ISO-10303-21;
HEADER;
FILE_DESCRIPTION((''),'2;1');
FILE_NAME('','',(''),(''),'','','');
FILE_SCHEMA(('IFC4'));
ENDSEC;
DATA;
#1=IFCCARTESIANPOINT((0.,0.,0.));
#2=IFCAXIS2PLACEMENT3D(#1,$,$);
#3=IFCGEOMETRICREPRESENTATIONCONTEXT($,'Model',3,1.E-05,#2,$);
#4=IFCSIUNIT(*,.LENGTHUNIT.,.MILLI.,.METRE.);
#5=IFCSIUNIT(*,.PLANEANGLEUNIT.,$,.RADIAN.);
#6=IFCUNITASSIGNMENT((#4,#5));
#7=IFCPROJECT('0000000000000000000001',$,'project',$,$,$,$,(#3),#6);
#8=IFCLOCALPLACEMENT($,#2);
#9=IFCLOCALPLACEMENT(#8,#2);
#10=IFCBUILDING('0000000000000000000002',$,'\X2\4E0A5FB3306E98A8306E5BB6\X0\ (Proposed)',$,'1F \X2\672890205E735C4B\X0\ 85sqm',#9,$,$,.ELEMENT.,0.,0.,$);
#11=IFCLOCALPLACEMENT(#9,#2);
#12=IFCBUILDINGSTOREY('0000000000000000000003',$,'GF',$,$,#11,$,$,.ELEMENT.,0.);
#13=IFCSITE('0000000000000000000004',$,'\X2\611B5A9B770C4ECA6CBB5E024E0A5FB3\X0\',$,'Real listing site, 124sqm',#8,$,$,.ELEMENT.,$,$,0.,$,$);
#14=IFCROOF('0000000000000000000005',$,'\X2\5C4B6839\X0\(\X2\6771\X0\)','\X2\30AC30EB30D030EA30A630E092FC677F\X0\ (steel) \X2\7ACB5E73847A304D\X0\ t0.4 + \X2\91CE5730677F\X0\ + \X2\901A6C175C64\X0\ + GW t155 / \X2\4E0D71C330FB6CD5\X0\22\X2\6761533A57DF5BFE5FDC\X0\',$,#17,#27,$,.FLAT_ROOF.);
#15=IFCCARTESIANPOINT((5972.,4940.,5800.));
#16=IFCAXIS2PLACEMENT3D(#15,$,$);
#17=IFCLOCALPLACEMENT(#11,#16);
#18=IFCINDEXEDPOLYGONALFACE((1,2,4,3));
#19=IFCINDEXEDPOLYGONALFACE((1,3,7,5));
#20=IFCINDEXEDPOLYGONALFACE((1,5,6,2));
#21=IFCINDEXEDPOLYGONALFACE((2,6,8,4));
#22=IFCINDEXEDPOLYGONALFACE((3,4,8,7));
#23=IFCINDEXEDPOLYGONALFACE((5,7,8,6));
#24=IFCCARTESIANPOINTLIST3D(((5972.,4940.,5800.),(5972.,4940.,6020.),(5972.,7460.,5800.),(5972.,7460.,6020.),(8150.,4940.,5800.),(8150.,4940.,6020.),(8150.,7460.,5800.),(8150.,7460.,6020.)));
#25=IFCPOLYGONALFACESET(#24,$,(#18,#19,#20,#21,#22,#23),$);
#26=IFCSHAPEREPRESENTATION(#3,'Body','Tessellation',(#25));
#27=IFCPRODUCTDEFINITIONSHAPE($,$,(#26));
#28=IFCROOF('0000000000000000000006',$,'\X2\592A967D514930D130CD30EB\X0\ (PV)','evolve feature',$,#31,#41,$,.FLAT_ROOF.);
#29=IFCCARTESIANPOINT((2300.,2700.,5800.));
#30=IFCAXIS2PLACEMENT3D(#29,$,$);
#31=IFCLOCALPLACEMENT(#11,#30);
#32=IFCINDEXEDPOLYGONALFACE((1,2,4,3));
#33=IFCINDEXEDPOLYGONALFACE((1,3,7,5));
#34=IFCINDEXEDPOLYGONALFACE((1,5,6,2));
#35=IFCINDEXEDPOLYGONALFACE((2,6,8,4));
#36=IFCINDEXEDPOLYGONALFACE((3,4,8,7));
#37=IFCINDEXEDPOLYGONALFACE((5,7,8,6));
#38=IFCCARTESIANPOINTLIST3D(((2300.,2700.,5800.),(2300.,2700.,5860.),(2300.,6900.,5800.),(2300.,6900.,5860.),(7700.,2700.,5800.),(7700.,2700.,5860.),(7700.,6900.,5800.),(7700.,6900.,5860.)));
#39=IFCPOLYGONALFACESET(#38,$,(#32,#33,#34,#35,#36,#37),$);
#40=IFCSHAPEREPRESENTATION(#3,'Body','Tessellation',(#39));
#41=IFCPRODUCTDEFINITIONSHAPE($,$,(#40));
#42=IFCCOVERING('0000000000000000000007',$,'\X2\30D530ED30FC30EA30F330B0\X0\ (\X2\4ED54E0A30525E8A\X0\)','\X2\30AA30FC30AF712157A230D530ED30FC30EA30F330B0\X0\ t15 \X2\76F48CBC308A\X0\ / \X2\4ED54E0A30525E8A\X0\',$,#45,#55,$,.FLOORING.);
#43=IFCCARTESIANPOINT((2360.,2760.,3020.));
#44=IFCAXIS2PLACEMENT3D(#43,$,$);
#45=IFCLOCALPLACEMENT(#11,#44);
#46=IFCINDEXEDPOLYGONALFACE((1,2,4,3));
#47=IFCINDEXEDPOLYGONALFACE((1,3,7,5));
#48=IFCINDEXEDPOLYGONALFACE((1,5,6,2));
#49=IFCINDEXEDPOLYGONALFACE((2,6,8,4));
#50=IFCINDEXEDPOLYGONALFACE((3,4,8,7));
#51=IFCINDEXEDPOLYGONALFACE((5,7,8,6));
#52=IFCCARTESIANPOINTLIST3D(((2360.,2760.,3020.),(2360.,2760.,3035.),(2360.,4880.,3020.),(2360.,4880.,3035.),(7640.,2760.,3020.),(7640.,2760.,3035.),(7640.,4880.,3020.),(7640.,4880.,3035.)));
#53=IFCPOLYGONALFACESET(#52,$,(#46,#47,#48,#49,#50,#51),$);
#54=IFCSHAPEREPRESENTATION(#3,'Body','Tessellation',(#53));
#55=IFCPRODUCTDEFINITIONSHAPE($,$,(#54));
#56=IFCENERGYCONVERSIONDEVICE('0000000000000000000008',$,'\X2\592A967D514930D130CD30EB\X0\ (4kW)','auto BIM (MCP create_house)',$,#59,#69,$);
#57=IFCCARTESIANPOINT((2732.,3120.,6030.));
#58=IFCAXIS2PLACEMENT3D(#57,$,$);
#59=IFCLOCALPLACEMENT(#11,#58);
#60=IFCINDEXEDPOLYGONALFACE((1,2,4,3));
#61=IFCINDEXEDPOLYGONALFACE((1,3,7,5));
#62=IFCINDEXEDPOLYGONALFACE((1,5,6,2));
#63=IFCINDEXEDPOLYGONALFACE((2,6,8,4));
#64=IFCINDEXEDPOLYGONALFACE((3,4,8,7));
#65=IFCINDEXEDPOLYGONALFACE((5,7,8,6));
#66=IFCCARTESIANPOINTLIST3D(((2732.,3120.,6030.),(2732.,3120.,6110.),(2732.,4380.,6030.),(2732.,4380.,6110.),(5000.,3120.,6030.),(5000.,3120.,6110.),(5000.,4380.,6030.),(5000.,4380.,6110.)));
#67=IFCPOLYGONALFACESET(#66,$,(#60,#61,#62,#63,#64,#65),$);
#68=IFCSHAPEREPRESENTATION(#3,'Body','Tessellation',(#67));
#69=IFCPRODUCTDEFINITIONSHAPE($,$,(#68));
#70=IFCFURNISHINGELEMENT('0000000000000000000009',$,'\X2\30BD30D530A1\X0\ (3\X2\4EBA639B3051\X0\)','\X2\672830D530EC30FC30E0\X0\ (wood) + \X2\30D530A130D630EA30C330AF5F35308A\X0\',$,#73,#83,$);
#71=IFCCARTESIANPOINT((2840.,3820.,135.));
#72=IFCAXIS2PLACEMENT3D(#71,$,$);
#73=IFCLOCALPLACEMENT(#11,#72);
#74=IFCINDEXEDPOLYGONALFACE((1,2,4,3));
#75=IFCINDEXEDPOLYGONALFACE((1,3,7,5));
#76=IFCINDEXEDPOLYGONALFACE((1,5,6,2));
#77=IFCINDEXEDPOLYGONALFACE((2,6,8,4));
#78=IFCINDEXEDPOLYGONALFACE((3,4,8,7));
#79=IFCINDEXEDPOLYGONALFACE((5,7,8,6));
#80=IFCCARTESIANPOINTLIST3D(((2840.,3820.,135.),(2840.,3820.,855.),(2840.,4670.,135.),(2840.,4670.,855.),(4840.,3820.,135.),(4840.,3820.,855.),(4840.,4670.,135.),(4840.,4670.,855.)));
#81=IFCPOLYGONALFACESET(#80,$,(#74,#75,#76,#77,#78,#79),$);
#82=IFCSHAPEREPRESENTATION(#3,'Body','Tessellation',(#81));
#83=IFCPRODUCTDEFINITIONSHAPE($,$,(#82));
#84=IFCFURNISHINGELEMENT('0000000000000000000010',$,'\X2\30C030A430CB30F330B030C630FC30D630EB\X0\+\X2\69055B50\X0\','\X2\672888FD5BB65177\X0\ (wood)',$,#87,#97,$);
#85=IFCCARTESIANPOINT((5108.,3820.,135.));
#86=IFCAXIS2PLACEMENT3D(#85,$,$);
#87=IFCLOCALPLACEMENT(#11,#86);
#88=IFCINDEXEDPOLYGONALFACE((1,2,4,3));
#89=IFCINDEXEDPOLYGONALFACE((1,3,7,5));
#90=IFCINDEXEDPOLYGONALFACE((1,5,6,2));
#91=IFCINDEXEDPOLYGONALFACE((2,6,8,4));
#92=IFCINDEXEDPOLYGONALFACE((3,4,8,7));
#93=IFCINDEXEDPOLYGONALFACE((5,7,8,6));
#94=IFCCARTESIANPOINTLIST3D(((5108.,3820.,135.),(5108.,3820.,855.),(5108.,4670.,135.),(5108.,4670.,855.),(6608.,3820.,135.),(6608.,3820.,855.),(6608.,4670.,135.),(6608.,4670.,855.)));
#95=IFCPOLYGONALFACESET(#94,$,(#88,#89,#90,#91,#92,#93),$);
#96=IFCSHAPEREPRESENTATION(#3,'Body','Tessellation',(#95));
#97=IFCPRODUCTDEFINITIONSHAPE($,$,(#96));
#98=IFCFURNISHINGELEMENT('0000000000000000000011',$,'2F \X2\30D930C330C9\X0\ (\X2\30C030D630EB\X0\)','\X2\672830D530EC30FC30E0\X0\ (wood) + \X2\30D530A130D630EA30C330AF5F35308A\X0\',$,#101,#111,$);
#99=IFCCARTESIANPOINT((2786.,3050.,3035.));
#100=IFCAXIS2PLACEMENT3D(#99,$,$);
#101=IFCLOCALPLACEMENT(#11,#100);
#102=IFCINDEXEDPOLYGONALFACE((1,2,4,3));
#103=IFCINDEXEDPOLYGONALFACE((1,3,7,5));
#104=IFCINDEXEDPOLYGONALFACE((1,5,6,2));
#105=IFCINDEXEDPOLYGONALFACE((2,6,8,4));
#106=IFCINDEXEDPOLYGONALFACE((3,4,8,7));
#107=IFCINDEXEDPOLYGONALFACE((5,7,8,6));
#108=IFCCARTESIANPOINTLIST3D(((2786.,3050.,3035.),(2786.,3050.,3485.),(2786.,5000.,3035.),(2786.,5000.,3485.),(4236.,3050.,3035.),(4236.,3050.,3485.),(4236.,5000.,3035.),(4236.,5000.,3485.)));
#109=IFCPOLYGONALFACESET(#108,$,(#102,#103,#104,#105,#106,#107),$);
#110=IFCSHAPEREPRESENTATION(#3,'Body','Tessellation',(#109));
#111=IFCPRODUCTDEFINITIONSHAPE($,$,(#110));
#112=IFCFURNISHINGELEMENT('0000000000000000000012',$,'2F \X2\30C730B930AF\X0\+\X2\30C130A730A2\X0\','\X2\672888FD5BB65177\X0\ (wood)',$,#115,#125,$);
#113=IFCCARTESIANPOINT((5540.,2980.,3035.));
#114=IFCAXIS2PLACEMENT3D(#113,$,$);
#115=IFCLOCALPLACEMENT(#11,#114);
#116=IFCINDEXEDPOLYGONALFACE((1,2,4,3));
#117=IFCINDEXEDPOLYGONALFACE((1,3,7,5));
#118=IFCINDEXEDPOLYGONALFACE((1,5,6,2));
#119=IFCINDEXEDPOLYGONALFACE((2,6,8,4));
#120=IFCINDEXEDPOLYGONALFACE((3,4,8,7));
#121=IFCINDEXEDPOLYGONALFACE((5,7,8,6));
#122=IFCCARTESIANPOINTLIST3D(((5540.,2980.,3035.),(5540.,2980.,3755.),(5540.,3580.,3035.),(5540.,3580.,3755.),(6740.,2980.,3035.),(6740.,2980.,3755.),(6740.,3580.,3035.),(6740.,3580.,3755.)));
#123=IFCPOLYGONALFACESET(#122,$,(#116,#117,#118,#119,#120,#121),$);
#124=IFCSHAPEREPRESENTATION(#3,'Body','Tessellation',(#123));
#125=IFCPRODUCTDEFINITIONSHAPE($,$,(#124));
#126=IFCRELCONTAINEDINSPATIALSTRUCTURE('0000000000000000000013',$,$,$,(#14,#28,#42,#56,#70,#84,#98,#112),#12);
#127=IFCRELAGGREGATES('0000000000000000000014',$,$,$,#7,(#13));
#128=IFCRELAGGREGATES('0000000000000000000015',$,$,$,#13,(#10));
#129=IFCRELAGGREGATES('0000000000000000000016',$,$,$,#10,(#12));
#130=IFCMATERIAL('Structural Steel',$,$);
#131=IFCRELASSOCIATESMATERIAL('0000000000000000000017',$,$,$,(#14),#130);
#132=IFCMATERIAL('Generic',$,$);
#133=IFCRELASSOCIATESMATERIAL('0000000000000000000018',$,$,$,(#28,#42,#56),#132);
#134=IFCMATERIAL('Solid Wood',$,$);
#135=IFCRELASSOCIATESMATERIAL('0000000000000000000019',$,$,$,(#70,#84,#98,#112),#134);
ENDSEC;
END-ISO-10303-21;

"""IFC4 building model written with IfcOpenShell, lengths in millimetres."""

from ifc_helpers import new_model, si_unit, frame, frame_2d, origin, place, context, project, spatial, rectangle, extrude, material, element, save


model = new_model("IFC4")

# Units and contexts
model_context = context("Model", 3, precision=1e-05, world=origin())
ifc_project = project(units=[si_unit("LENGTHUNIT", "METRE", prefix="MILLI"), si_unit("PLANEANGLEUNIT", "RADIAN")], contexts=[model_context])

# Site, building, storey
site_placement = place(None, origin())
site = spatial("IfcSite", under=ifc_project, at=site_placement, Name="愛媛県今治市上徳", ObjectType="Real listing site, 124sqm", CompositionType="ELEMENT", RefElevation=0.0)
building_placement = place(site_placement, origin())
building = spatial("IfcBuilding", under=site, at=building_placement, Name="上徳の風の家 (Proposed)", ObjectType="1F 木造平屋 85sqm", CompositionType="ELEMENT", ElevationOfRefHeight=0.0, ElevationOfTerrain=0.0)
storey_placement = place(building_placement, origin())
storey = spatial("IfcBuildingStorey", under=building, at=storey_placement, Name="GF", CompositionType="ELEMENT", Elevation=0.0)

# Shared definitions
ifc_material_1 = material(Name="Solid Wood")

# Roofs
ifc_material_2 = material(Name="Structural Steel")
roof_1_placement = place(storey_placement, frame((5972.0, 4940.0, 5800.0)))
element("IfcRoof", 1, at=roof_1_placement, inside=storey, material=ifc_material_2, Name="屋根(東)", Description="ガルバリウム鋼板 (steel) 立平葺き t0.4 + 野地板 + 通気層 + GW t155 / 不燃・法22条区域対応", PredefinedType="FLAT_ROOF", context=model_context, shape_type="SweptSolid", body=[
    extrude(rectangle(XDim=2178.0, YDim=2520.0, at=frame_2d((1089.0, 1260.0))), frame((5972.0, 4940.0, 5800.0)), (0.0, 0.0, 1.0), 220.0),
])
ifc_material_3 = material(Name="Generic")
roof_2_placement = place(storey_placement, frame((2300.0, 2700.0, 5800.0)))
element("IfcRoof", 2, at=roof_2_placement, inside=storey, material=ifc_material_3, Name="太陽光パネル (PV)", Description="evolve feature", PredefinedType="FLAT_ROOF", context=model_context, shape_type="SweptSolid", body=[
    extrude(rectangle(XDim=5400.0, YDim=4200.0, at=frame_2d((2700.0, 2100.0))), frame((2300.0, 2700.0, 5800.0)), (0.0, 0.0, 1.0), 60.0),
])

# Covering
covering_placement = place(storey_placement, frame((2360.0, 2760.0, 3020.0)))
element("IfcCovering", 3, at=covering_placement, inside=storey, material=ifc_material_3, Name="フローリング (仕上げ床)", Description="オーク無垢フローリング t15 直貼り / 仕上げ床", PredefinedType="FLOORING", context=model_context, shape_type="SweptSolid", body=[
    extrude(rectangle(XDim=5280.0, YDim=2120.0, at=frame_2d((2640.0, 1060.0))), frame((2360.0, 2760.0, 3020.0)), (0.0, 0.0, 1.0), 15.0),
])

# Energy conversion device
energy_conversion_device_placement = place(storey_placement, frame((2732.0, 3120.0, 6030.0)))
element("IfcEnergyConversionDevice", 4, at=energy_conversion_device_placement, inside=storey, material=ifc_material_3, Name="太陽光パネル (4kW)", Description="auto BIM (MCP create_house)", context=model_context, shape_type="SweptSolid", body=[
    extrude(rectangle(XDim=2268.0, YDim=1260.0, at=frame_2d((1134.0, 630.0))), frame((2732.0, 3120.0, 6030.0)), (0.0, 0.0, 1.0), 80.0),
])

# Furnishing elements
furnishing_1_placement = place(storey_placement, frame((2840.0, 3820.0, 135.0)))
element("IfcFurnishingElement", 5, at=furnishing_1_placement, inside=storey, material=ifc_material_1, Name="ソファ (3人掛け)", Description="木フレーム (wood) + ファブリック張り", context=model_context, shape_type="SweptSolid", body=[
    extrude(rectangle(XDim=2000.0, YDim=850.0, at=frame_2d((1000.0, 425.0))), frame((2840.0, 3820.0, 135.0)), (0.0, 0.0, 1.0), 720.0),
])
furnishing_2_placement = place(storey_placement, frame((5108.0, 3820.0, 135.0)))
element("IfcFurnishingElement", 6, at=furnishing_2_placement, inside=storey, material=ifc_material_1, Name="ダイニングテーブル+椅子", Description="木製家具 (wood)", context=model_context, shape_type="SweptSolid", body=[
    extrude(rectangle(XDim=1500.0, YDim=850.0, at=frame_2d((750.0, 425.0))), frame((5108.0, 3820.0, 135.0)), (0.0, 0.0, 1.0), 720.0),
])
furnishing_3_placement = place(storey_placement, frame((2786.0, 3050.0, 3035.0)))
element("IfcFurnishingElement", 7, at=furnishing_3_placement, inside=storey, material=ifc_material_1, Name="2F ベッド (ダブル)", Description="木フレーム (wood) + ファブリック張り", context=model_context, shape_type="SweptSolid", body=[
    extrude(rectangle(XDim=1450.0, YDim=1950.0, at=frame_2d((725.0, 975.0))), frame((2786.0, 3050.0, 3035.0)), (0.0, 0.0, 1.0), 450.0),
])
furnishing_4_placement = place(storey_placement, frame((5540.0, 2980.0, 3035.0)))
element("IfcFurnishingElement", 8, at=furnishing_4_placement, inside=storey, material=ifc_material_1, Name="2F デスク+チェア", Description="木製家具 (wood)", context=model_context, shape_type="SweptSolid", body=[
    extrude(rectangle(XDim=1200.0, YDim=600.0, at=frame_2d((600.0, 300.0))), frame((5540.0, 2980.0, 3035.0)), (0.0, 0.0, 1.0), 720.0),
])

save(model, "model.ifc")
